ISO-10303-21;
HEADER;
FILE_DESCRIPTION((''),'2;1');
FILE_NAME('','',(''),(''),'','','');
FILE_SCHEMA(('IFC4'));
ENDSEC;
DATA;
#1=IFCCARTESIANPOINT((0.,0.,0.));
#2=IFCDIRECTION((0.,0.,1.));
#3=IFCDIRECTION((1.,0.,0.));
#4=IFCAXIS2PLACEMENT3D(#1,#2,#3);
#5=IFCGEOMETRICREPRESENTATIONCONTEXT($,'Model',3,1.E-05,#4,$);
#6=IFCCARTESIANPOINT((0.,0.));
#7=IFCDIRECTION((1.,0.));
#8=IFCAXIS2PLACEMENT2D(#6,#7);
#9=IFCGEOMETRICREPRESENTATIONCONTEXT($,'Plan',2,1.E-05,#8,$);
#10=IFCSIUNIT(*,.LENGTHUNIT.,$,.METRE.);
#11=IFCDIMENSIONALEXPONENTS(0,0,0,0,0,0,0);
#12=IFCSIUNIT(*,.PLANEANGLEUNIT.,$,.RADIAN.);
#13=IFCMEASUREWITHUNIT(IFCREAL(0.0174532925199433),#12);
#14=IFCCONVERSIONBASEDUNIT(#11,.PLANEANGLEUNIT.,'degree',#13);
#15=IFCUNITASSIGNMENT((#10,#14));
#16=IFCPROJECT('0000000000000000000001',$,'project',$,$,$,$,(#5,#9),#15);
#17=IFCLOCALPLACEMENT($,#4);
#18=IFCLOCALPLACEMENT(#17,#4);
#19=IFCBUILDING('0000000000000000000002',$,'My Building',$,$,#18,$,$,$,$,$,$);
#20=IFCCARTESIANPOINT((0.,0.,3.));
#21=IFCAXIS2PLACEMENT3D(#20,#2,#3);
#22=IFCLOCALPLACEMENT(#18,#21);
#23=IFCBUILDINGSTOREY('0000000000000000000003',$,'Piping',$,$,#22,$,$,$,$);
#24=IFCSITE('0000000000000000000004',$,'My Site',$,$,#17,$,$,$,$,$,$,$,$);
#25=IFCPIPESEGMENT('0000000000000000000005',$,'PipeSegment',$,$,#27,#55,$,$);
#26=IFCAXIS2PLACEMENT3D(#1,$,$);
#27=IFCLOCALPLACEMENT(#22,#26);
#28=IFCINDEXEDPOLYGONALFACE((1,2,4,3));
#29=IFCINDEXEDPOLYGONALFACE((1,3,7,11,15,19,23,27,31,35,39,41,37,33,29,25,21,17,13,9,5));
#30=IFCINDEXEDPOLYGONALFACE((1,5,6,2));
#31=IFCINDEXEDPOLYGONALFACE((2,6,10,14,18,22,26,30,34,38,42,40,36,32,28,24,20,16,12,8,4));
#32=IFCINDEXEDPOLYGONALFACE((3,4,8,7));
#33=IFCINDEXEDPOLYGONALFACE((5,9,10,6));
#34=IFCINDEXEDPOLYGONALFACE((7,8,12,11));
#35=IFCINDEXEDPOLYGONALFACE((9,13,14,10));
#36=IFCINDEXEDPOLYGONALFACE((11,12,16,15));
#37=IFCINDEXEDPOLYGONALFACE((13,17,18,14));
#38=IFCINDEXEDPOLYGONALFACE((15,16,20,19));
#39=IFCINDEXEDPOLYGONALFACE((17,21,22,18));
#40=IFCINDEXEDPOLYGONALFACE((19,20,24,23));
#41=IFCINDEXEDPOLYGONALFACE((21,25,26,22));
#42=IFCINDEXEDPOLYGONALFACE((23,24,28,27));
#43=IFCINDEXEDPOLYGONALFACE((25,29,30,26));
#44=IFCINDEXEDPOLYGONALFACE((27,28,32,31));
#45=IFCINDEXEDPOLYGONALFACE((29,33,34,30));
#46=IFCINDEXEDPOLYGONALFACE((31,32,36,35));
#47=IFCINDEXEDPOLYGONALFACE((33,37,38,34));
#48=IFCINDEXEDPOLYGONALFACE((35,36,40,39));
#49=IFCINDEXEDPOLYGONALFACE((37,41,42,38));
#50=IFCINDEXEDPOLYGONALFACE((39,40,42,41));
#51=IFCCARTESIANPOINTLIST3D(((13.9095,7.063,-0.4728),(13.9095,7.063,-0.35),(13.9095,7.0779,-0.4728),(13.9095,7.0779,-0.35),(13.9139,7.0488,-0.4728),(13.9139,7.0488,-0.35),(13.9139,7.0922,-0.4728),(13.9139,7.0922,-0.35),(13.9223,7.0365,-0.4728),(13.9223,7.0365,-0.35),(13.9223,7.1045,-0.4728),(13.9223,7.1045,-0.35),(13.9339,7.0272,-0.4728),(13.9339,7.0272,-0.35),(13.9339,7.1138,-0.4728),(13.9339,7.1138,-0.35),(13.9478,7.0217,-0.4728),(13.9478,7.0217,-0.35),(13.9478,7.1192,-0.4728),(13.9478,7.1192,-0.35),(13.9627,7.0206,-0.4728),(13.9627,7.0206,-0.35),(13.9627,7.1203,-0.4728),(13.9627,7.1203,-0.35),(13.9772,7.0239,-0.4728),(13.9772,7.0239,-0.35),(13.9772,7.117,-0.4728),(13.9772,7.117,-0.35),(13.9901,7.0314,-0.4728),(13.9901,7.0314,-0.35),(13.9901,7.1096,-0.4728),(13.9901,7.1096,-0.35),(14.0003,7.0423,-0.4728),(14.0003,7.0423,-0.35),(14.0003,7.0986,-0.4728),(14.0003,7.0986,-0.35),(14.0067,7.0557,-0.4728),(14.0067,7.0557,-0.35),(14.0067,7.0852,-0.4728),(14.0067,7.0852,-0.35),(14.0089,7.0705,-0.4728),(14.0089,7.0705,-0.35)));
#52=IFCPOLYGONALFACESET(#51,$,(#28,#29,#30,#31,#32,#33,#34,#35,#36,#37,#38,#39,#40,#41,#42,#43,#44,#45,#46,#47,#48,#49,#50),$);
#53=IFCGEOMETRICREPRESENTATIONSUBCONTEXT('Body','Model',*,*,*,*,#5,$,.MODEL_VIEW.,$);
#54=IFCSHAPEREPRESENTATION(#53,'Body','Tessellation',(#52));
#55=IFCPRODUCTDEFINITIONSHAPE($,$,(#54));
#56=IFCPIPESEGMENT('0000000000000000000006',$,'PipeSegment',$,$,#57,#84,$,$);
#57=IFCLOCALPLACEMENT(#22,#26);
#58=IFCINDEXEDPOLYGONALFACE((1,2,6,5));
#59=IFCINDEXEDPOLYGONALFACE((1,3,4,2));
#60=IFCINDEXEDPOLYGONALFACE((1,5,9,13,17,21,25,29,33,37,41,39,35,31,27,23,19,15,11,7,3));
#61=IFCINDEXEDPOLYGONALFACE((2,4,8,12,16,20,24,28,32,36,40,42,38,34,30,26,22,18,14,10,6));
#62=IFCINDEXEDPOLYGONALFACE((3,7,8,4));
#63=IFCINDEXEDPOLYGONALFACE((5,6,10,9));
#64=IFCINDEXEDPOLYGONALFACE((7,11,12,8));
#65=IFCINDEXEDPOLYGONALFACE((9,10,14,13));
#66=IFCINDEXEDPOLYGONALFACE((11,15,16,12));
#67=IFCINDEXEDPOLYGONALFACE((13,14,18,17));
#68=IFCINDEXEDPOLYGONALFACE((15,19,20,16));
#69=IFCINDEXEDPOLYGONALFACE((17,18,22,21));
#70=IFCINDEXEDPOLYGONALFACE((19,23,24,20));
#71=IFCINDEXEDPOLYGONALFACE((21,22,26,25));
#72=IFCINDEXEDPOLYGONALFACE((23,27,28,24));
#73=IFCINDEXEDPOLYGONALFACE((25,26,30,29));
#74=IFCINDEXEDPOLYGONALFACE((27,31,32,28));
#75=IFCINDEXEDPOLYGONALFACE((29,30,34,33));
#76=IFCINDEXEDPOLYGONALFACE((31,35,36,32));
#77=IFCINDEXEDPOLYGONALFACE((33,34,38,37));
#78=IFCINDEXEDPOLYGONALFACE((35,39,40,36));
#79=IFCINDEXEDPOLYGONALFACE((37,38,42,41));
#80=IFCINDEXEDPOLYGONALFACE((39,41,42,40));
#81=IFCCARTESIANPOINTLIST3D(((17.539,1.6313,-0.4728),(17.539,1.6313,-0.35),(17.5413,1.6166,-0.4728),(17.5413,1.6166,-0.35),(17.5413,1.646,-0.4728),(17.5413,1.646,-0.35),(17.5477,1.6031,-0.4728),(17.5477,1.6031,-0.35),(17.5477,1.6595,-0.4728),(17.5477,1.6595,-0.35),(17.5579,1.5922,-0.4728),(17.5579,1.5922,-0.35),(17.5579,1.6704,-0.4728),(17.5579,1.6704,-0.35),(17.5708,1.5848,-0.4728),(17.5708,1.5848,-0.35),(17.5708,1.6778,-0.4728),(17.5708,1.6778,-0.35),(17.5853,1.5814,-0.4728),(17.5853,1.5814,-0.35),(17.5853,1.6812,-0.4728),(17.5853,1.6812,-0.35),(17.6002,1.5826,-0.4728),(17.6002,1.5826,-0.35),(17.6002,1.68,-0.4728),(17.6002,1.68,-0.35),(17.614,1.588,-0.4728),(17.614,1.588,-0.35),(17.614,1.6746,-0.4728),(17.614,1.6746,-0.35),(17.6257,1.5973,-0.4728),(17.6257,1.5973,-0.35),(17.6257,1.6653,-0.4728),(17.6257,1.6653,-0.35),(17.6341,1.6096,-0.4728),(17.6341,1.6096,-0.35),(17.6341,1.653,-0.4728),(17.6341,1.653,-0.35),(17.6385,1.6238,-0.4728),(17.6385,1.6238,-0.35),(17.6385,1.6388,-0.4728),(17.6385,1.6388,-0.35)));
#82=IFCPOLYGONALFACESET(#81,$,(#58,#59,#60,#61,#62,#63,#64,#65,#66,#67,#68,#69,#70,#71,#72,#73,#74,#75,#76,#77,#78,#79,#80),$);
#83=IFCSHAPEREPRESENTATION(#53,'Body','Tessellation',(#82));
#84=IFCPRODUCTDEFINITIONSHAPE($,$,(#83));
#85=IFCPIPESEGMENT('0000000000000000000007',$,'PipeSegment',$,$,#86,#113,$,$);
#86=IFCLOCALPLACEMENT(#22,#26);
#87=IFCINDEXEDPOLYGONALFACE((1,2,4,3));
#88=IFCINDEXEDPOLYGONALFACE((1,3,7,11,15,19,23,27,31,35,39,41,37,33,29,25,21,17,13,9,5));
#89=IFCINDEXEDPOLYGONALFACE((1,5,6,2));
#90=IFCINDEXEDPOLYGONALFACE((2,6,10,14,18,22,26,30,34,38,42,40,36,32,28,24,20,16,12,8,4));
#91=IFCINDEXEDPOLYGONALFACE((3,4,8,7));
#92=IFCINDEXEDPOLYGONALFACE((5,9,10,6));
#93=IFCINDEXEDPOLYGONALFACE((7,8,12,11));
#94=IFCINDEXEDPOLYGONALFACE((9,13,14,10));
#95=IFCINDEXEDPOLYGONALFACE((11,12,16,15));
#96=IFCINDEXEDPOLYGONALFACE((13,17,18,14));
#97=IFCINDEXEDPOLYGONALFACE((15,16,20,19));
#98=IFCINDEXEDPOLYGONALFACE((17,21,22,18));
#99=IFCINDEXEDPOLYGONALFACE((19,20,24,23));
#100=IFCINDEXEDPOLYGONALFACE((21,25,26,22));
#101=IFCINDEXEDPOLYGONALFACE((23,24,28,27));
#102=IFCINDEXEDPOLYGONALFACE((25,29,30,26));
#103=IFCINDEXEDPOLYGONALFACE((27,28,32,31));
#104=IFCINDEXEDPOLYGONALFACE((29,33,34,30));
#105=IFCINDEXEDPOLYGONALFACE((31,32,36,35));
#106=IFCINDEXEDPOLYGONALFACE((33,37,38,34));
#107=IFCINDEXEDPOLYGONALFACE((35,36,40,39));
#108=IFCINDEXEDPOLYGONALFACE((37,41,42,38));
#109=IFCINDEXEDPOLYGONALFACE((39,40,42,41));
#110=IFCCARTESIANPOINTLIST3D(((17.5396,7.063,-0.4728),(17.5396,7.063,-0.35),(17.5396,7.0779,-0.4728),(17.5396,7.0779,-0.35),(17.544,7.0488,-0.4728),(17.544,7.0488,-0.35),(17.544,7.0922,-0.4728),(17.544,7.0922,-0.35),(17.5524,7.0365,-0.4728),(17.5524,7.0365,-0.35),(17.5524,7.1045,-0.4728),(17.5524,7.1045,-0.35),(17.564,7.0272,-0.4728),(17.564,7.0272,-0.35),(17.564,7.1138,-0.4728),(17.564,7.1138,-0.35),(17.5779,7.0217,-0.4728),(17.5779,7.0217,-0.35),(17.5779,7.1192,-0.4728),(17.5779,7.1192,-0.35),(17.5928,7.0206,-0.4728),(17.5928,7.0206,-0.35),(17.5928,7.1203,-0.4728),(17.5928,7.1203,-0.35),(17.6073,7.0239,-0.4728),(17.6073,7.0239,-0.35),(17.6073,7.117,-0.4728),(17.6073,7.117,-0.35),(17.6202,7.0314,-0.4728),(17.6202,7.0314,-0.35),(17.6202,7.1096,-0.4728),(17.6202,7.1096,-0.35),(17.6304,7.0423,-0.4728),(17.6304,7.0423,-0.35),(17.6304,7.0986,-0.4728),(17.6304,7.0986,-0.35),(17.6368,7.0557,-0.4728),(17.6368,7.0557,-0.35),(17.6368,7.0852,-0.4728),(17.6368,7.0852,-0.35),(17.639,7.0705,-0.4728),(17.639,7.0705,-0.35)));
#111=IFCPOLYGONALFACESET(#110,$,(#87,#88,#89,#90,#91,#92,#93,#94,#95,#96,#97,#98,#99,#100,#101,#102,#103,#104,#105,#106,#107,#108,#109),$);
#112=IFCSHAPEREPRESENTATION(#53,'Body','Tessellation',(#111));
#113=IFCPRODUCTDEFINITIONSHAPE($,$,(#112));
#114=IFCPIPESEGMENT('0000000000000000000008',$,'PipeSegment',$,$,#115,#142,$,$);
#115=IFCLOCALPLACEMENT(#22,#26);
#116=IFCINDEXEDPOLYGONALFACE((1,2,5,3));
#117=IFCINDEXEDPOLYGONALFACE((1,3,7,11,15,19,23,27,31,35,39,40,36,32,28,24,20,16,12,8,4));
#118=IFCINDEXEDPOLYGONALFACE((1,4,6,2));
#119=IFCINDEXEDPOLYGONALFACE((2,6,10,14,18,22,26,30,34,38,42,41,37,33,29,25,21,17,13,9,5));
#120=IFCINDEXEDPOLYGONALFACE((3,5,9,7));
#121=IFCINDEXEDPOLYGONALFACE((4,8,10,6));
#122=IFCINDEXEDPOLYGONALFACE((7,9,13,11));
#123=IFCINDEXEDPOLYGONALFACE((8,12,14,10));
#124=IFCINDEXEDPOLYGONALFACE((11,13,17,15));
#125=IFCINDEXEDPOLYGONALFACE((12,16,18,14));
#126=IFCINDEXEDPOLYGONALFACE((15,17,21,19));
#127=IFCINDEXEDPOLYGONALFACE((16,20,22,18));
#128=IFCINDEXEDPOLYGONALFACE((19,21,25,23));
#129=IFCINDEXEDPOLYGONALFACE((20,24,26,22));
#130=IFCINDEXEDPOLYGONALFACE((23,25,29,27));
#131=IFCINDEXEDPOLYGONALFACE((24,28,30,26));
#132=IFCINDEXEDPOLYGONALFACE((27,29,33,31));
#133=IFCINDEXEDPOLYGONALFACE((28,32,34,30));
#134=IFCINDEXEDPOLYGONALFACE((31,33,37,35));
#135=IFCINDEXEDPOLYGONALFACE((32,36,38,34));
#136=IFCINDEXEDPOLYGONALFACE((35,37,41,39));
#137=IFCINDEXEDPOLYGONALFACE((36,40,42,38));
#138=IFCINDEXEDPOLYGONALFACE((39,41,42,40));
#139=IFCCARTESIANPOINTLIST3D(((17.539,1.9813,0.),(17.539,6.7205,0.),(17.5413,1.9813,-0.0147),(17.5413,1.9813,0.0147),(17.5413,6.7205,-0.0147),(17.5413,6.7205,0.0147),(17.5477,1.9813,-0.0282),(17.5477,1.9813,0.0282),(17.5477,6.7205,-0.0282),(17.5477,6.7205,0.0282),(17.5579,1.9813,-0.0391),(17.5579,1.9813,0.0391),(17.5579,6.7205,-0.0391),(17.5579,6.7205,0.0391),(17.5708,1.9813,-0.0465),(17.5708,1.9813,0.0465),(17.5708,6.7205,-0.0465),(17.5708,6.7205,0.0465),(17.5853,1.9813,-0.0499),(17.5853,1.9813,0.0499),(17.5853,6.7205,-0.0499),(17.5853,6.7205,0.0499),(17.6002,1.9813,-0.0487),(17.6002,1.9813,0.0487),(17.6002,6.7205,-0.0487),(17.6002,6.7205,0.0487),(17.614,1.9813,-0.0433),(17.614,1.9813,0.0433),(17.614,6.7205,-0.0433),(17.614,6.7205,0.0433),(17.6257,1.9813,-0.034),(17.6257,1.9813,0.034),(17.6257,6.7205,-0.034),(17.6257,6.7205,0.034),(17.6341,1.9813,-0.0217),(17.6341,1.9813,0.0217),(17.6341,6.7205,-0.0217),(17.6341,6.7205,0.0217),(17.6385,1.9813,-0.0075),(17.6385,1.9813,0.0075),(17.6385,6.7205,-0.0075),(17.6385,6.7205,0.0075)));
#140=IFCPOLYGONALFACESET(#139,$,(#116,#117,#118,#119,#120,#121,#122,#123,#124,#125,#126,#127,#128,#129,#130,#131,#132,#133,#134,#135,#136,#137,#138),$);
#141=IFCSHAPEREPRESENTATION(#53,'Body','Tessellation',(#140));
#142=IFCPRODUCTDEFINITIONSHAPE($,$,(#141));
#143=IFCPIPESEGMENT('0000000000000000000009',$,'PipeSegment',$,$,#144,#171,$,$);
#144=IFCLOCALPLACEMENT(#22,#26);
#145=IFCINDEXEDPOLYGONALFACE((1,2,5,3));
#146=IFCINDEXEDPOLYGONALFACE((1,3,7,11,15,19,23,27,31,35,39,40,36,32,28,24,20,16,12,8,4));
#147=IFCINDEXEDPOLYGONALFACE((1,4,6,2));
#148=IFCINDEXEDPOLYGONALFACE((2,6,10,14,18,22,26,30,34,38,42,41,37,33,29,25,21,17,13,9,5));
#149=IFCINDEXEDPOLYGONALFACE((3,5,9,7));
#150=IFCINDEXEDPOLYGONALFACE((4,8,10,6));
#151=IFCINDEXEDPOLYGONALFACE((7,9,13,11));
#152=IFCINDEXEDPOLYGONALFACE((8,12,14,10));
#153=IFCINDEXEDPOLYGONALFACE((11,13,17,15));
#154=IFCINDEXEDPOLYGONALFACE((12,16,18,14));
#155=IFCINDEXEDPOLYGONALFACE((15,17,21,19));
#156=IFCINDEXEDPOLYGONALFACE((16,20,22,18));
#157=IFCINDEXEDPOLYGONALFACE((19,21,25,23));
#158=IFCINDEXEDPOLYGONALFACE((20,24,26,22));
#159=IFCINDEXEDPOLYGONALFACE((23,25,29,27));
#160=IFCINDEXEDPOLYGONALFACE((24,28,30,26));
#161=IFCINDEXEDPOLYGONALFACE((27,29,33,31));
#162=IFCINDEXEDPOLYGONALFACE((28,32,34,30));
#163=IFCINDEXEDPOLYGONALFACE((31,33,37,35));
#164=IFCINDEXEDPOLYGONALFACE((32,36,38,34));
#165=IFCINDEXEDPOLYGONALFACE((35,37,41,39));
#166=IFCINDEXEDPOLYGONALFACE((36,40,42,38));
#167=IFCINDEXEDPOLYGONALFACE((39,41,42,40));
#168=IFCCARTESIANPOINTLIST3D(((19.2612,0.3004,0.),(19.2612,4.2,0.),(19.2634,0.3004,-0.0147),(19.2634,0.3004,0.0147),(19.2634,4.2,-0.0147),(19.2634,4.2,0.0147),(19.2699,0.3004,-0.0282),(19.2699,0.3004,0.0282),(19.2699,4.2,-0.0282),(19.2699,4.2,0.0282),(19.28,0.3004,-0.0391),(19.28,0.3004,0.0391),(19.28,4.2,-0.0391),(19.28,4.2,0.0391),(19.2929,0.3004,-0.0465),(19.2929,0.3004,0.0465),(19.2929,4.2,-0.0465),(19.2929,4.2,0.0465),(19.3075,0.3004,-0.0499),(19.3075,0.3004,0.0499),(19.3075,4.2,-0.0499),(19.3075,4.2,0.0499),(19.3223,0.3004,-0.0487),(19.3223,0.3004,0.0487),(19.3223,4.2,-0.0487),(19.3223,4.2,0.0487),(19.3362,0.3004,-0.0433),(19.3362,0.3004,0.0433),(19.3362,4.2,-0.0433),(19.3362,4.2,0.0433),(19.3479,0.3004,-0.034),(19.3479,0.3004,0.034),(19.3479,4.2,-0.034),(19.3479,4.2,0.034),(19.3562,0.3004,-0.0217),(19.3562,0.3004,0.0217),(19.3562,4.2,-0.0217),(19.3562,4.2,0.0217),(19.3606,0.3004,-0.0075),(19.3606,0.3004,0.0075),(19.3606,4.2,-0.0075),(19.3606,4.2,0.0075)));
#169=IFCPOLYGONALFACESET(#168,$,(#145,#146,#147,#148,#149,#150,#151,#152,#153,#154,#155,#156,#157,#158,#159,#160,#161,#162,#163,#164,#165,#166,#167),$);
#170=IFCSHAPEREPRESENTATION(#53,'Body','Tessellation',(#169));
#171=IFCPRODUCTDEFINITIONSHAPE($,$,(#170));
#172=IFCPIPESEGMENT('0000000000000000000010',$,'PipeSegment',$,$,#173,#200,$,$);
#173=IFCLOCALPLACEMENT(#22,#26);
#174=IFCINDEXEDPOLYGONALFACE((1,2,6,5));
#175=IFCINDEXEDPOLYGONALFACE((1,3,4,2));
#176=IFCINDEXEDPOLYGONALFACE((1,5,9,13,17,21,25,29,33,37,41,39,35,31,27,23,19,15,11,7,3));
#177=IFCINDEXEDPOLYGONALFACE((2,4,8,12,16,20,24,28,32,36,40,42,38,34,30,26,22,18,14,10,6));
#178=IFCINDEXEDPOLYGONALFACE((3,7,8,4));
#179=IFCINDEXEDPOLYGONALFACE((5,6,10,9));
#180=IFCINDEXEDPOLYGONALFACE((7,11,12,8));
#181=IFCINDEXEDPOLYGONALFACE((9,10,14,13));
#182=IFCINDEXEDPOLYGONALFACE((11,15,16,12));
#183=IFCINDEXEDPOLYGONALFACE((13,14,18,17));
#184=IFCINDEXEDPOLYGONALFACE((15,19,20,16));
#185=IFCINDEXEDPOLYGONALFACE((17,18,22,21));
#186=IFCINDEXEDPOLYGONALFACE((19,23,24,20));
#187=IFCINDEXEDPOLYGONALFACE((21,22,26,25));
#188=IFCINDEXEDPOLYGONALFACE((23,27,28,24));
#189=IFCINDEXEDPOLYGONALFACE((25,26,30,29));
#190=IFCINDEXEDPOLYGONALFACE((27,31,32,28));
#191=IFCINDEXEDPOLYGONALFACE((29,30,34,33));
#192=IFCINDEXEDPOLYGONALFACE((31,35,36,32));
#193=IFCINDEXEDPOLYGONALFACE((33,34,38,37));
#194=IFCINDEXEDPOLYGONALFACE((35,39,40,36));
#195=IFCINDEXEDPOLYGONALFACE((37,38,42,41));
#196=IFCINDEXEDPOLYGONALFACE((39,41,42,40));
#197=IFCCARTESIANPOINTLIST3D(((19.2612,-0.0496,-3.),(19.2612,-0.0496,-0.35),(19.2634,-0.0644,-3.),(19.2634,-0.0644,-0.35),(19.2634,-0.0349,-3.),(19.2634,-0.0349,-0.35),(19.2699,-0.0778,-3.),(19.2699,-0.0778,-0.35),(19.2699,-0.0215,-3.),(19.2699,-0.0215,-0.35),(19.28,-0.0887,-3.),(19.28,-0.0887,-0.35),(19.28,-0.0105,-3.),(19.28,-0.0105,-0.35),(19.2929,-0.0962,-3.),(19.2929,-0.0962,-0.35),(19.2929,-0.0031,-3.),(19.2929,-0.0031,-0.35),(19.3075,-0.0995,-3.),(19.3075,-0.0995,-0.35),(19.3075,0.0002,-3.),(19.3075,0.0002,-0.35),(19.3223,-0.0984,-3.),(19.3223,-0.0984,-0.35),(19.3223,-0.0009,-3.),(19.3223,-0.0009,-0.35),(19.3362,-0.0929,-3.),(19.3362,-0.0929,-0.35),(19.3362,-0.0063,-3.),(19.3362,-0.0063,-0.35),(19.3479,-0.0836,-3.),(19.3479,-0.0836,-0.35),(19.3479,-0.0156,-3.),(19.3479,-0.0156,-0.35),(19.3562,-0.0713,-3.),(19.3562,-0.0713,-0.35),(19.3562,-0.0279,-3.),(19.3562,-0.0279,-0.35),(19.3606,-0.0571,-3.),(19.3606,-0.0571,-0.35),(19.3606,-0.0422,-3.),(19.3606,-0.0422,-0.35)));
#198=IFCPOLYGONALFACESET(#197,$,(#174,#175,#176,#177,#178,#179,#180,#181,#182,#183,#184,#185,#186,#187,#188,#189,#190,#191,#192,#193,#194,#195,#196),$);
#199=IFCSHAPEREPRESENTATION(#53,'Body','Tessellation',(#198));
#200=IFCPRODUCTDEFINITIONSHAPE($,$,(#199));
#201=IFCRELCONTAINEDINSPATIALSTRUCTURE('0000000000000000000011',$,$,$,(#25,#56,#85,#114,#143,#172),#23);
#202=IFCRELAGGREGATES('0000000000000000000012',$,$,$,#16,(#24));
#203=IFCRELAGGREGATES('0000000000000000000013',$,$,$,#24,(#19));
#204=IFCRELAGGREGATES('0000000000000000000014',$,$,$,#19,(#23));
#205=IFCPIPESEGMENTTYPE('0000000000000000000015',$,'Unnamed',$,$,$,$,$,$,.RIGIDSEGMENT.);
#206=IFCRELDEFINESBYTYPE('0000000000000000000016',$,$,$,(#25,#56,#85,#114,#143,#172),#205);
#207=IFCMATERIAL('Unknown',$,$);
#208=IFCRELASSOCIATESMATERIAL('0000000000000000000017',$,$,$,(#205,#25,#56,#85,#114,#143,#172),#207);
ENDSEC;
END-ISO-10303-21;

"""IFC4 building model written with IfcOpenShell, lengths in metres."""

from ifc_helpers import new_model, entity, si_unit, converted_unit, frame, origin_with_axes, origin_2d_with_axis, place, context, subcontext, project, spatial, circle, extrude, material, material_profile, profile_set, profile_usage, type_object, element, save


model = new_model("IFC4")

# Units and contexts
model_context = context("Model", 3, precision=1e-05, world=origin_with_axes())
plan_context = context("Plan", 2, precision=1e-05, world=origin_2d_with_axis())
body_context = subcontext(model_context, "Body", "Model", "MODEL_VIEW")
ifc_project = project(units=[si_unit("LENGTHUNIT", "METRE"), converted_unit("PLANEANGLEUNIT", "degree", entity("IfcReal", 0.0174532925199433), si_unit("PLANEANGLEUNIT", "RADIAN"), dimensions=[0, 0, 0, 0, 0, 0, 0])], contexts=[model_context, plan_context])

# Site, building, storey
site_placement = place(None, origin_with_axes())
site = spatial("IfcSite", under=ifc_project, at=site_placement, Name="My Site")
building_placement = place(site_placement, origin_with_axes())
building = spatial("IfcBuilding", under=site, at=building_placement, Name="My Building")
storey_placement = place(building_placement, frame((0.0, 0.0, 3.0), z_axis=(0.0, 0.0, 1.0), x_axis=(1.0, 0.0, 0.0)))
storey = spatial("IfcBuildingStorey", under=building, at=storey_placement, Name="Piping")

# Pipe segments
ifc_material = material(Name="Unknown")
ifc_material_profile = material_profile(ifc_material, circle(Radius=0.05))
ifc_profile_set = profile_set([ifc_material_profile])
pipe_segment_type = type_object("IfcPipeSegmentType", Name="Unnamed", PredefinedType="RIGIDSEGMENT", material=ifc_profile_set)
ifc_profile_usage_1 = profile_usage(ifc_profile_set, cardinal=5)
pipe_segment_1_placement = place(storey_placement, frame((13.9589, 7.0705, -0.35), z_axis=(0.0, 0.0, -1.0), x_axis=(1.0, 0.0, 0.0)))
element("IfcPipeSegment", 1, at=pipe_segment_1_placement, inside=storey, type_object=pipe_segment_type, material=ifc_profile_usage_1, Name="PipeSegment", context=body_context, shape_type="SweptSolid", body=[
    extrude(circle(Radius=0.05), origin_with_axes(), (0.0, 0.0, 1.0), 0.1228),
])
ifc_profile_usage_2 = profile_usage(ifc_profile_set, cardinal=5)
pipe_segment_2_placement = place(storey_placement, frame((17.589, 1.6313, -0.35), z_axis=(0.0, 0.0, -1.0), x_axis=(-1.0, 0.0, 0.0)))
element("IfcPipeSegment", 2, at=pipe_segment_2_placement, inside=storey, type_object=pipe_segment_type, material=ifc_profile_usage_2, Name="PipeSegment", context=body_context, shape_type="SweptSolid", body=[
    extrude(circle(Radius=0.05), origin_with_axes(), (0.0, 0.0, 1.0), 0.1228),
])
ifc_profile_usage_3 = profile_usage(ifc_profile_set, cardinal=5)
pipe_segment_3_placement = place(storey_placement, frame((17.589, 7.0705, -0.35), z_axis=(0.0, 0.0, -1.0), x_axis=(1.0, 0.0, 0.0)))
element("IfcPipeSegment", 3, at=pipe_segment_3_placement, inside=storey, type_object=pipe_segment_type, material=ifc_profile_usage_3, Name="PipeSegment", context=body_context, shape_type="SweptSolid", body=[
    extrude(circle(Radius=0.05), origin_with_axes(), (0.0, 0.0, 1.0), 0.1228),
])
ifc_profile_usage_4 = profile_usage(ifc_profile_set, cardinal=5)
pipe_segment_4_placement = place(storey_placement, frame((17.589, 1.9813, 0.0), z_axis=(0.0, 1.0, 0.0), x_axis=(-1.0, 0.0, 0.0)))
element("IfcPipeSegment", 4, at=pipe_segment_4_placement, inside=storey, type_object=pipe_segment_type, material=ifc_profile_usage_4, Name="PipeSegment", context=body_context, shape_type="SweptSolid", body=[
    extrude(circle(Radius=0.05), origin_with_axes(), (0.0, 0.0, 1.0), 4.7392),
])
ifc_profile_usage_5 = profile_usage(ifc_profile_set, cardinal=5)
pipe_segment_5_placement = place(storey_placement, frame((19.3112, 0.3004, 0.0), z_axis=(0.0, 1.0, 0.0), x_axis=(-1.0, 0.0, 0.0)))
element("IfcPipeSegment", 5, at=pipe_segment_5_placement, inside=storey, type_object=pipe_segment_type, material=ifc_profile_usage_5, Name="PipeSegment", context=body_context, shape_type="SweptSolid", body=[
    extrude(circle(Radius=0.05), origin_with_axes(), (0.0, 0.0, 1.0), 3.8996),
])
ifc_profile_usage_6 = profile_usage(ifc_profile_set, cardinal=5)
pipe_segment_6_placement = place(storey_placement, frame((19.3112, -0.0496, -0.35), z_axis=(0.0, 0.0, -1.0), x_axis=(-1.0, 0.0, 0.0)))
element("IfcPipeSegment", 6, at=pipe_segment_6_placement, inside=storey, type_object=pipe_segment_type, material=ifc_profile_usage_6, Name="PipeSegment", context=body_context, shape_type="SweptSolid", body=[
    extrude(circle(Radius=0.05), origin_with_axes(), (0.0, 0.0, 1.0), 2.65),
])

save(model, "model.ifc")
